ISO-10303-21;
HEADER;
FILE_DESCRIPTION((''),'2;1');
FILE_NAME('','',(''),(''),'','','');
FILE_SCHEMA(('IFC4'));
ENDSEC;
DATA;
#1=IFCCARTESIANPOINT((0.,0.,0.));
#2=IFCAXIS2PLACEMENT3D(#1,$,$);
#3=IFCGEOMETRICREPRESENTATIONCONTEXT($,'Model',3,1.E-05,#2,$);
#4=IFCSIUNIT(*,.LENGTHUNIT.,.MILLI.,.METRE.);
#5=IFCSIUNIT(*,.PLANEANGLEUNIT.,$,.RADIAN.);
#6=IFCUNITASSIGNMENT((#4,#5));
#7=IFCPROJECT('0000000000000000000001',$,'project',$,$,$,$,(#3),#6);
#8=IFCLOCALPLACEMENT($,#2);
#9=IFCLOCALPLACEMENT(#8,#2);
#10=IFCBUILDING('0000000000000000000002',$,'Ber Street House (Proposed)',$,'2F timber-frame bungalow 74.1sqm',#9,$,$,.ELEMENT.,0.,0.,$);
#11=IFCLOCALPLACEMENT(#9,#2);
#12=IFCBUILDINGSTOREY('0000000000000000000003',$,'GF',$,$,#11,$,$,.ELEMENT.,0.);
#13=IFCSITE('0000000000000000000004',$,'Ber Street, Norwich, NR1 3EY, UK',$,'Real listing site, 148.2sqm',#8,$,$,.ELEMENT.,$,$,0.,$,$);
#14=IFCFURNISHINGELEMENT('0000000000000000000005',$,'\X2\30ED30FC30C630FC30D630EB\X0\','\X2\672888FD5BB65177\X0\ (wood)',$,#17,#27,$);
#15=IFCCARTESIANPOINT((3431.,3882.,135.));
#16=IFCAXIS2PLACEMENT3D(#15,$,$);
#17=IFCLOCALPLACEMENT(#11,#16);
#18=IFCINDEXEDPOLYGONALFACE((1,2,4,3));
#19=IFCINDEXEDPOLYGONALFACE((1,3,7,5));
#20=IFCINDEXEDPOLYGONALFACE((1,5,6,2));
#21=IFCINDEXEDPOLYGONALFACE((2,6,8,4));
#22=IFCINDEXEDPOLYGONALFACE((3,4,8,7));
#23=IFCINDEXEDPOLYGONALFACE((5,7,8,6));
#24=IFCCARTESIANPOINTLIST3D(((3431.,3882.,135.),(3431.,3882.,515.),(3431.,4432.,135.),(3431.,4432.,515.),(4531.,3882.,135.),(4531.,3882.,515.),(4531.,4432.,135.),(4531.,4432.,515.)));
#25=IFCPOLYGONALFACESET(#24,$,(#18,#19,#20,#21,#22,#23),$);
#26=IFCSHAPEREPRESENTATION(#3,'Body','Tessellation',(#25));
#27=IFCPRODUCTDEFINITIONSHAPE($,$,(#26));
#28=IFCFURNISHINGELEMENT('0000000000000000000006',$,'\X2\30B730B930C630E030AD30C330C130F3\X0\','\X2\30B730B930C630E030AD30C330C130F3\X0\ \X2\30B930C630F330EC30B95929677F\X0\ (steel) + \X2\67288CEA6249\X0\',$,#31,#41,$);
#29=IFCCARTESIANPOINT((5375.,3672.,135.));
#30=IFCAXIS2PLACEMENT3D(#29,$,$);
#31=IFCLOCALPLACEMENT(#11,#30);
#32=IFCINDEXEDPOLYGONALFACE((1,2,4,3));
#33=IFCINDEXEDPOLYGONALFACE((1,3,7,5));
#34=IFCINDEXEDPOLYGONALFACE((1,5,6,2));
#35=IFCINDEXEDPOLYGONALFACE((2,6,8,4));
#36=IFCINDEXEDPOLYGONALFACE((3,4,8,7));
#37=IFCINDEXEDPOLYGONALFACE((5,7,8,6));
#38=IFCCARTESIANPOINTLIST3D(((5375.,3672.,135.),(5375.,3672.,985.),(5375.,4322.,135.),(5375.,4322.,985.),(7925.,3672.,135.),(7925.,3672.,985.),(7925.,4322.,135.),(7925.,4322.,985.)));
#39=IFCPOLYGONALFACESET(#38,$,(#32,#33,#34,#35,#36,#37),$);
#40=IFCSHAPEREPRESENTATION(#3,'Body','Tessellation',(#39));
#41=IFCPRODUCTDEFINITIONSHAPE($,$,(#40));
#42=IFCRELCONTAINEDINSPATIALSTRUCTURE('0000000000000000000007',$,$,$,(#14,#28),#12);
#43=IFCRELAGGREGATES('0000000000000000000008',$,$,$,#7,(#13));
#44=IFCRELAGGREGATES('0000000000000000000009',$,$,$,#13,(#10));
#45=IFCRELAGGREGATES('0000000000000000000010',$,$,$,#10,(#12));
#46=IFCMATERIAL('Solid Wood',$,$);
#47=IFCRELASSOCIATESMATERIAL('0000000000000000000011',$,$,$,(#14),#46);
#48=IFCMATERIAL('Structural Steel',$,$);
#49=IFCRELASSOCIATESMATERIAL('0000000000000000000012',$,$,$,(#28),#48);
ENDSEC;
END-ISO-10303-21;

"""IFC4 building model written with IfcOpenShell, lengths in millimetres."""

from ifc_helpers import new_model, si_unit, frame, frame_2d, origin, place, context, project, spatial, rectangle, extrude, material, element, save


model = new_model("IFC4")

# Units and contexts
model_context = context("Model", 3, precision=1e-05, world=origin())
ifc_project = project(units=[si_unit("LENGTHUNIT", "METRE", prefix="MILLI"), si_unit("PLANEANGLEUNIT", "RADIAN")], contexts=[model_context])

# Site, building, storey
site_placement = place(None, origin())
site = spatial("IfcSite", under=ifc_project, at=site_placement, Name="Ber Street, Norwich, NR1 3EY, UK", ObjectType="Real listing site, 148.2sqm", CompositionType="ELEMENT", RefElevation=0.0)
building_placement = place(site_placement, origin())
building = spatial("IfcBuilding", under=site, at=building_placement, Name="Ber Street House (Proposed)", ObjectType="2F timber-frame bungalow 74.1sqm", CompositionType="ELEMENT", ElevationOfRefHeight=0.0, ElevationOfTerrain=0.0)
storey_placement = place(building_placement, origin())
storey = spatial("IfcBuildingStorey", under=building, at=storey_placement, Name="GF", CompositionType="ELEMENT", Elevation=0.0)

# Shared definitions
ifc_material_1 = material(Name="Solid Wood")

# Furnishing elements
furnishing_1_placement = place(storey_placement, frame((3431.0, 3882.0, 135.0)))
element("IfcFurnishingElement", 1, at=furnishing_1_placement, inside=storey, material=ifc_material_1, Name="ローテーブル", Description="木製家具 (wood)", context=model_context, shape_type="SweptSolid", body=[
    extrude(rectangle(XDim=1100.0, YDim=550.0, at=frame_2d((550.0, 275.0))), frame((3431.0, 3882.0, 135.0)), (0.0, 0.0, 1.0), 380.0),
])
ifc_material_2 = material(Name="Structural Steel")
furnishing_2_placement = place(storey_placement, frame((5375.0, 3672.0, 135.0)))
element("IfcFurnishingElement", 2, at=furnishing_2_placement, inside=storey, material=ifc_material_2, Name="システムキッチン", Description="システムキッチン ステンレス天板 (steel) + 木質扉", context=model_context, shape_type="SweptSolid", body=[
    extrude(rectangle(XDim=2550.0, YDim=650.0, at=frame_2d((1275.0, 325.0))), frame((5375.0, 3672.0, 135.0)), (0.0, 0.0, 1.0), 850.0),
])

save(model, "model.ifc")
